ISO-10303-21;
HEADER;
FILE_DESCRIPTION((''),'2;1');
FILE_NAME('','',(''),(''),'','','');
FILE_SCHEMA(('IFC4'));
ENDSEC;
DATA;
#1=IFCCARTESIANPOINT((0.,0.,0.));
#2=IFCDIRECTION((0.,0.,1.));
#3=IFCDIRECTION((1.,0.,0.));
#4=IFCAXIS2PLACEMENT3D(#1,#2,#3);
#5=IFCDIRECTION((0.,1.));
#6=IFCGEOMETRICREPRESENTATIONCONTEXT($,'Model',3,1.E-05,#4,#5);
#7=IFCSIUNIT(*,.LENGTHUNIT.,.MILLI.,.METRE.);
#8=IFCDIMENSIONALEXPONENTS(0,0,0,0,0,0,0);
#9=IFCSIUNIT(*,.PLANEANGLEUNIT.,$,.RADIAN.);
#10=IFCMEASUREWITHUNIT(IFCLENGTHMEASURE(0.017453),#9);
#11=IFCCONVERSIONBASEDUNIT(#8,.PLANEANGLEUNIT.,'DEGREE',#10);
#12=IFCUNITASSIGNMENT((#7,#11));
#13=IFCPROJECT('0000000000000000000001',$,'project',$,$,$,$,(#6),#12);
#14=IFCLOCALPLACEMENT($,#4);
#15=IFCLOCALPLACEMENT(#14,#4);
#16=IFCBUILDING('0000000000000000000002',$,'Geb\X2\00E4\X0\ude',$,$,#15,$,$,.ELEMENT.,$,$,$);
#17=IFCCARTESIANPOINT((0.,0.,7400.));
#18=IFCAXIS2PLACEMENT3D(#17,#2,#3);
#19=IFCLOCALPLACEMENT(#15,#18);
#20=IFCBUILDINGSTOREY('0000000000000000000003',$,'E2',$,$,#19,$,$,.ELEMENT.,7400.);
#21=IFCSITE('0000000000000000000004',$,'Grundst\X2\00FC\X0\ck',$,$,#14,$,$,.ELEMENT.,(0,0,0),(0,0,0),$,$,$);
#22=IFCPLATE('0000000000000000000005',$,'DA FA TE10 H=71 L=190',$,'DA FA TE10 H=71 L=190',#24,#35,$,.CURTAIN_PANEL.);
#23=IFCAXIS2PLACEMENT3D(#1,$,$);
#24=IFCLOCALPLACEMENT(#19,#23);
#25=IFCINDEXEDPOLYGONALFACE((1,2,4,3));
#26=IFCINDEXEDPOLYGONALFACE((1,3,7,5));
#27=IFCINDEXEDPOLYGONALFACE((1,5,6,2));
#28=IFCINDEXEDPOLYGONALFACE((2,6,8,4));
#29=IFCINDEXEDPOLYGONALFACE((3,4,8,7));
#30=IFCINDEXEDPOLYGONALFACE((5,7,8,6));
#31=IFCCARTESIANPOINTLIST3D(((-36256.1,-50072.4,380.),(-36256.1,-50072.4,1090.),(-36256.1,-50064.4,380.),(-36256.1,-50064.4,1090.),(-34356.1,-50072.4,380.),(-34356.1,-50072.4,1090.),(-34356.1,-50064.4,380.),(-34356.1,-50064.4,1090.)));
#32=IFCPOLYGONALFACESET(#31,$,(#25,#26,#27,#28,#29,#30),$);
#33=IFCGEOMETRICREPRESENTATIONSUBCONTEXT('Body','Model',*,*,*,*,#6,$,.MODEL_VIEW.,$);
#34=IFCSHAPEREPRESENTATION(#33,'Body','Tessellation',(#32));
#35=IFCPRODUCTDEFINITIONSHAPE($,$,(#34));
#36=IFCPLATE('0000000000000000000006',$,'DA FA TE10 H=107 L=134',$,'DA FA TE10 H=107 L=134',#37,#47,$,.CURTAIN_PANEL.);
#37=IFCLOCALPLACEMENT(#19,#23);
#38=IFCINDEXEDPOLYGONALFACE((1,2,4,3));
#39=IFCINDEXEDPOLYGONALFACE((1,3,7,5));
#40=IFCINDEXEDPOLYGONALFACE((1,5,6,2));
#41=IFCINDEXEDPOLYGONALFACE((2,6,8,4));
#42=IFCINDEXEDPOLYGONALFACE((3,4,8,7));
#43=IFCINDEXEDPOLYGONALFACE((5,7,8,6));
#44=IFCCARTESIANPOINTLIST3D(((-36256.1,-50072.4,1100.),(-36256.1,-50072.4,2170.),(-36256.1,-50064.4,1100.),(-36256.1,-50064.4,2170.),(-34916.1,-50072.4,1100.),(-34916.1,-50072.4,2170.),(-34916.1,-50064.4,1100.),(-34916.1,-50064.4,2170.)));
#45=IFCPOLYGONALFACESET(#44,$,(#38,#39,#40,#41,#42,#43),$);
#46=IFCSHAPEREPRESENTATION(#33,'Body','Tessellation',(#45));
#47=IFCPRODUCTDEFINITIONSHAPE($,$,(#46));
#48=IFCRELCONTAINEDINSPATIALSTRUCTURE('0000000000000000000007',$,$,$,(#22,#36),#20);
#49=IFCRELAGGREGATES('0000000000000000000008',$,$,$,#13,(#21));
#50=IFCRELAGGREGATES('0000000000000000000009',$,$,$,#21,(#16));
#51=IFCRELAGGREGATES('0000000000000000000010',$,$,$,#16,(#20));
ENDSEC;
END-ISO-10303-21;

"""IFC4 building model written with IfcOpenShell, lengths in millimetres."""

from ifc_helpers import new_model, entity, si_unit, converted_unit, direction, frame, origin_with_axes, place, context, subcontext, project, spatial, line, indexed_curve, outline, extrude, source, transform, mapped, element, save


model = new_model("IFC4")

# Units and contexts
model_context = context("Model", 3, precision=1e-05, world=origin_with_axes(), true_north=direction((0.0, 1.0)))
body_context = subcontext(model_context, "Body", "Model", "MODEL_VIEW")
ifc_project = project(units=[si_unit("LENGTHUNIT", "METRE", prefix="MILLI"), converted_unit("PLANEANGLEUNIT", "DEGREE", entity("IfcLengthMeasure", 0.017453), si_unit("PLANEANGLEUNIT", "RADIAN"), dimensions=[0, 0, 0, 0, 0, 0, 0])], contexts=[model_context])

# Site, building, storey
site_placement = place(None, origin_with_axes())
site = spatial("IfcSite", under=ifc_project, at=site_placement, Name="Grundstück", CompositionType="ELEMENT", RefLatitude=(0, 0, 0), RefLongitude=(0, 0, 0))
building_placement = place(site_placement, origin_with_axes())
building = spatial("IfcBuilding", under=site, at=building_placement, Name="Gebäude", CompositionType="ELEMENT")
storey_placement = place(building_placement, frame((0.0, 0.0, 7400.0), z_axis=(0.0, 0.0, 1.0), x_axis=(1.0, 0.0, 0.0)))
storey = spatial("IfcBuildingStorey", under=building, at=storey_placement, Name="E2", CompositionType="ELEMENT", Elevation=7400.0)

# Plates
shared_shape_1 = source(origin_with_axes(), body_context, "Body", "SweptSolid", [
    extrude(outline(indexed_curve([(-950.0, 0.0), (950.0, 0.0), (950.0, 8.0), (-950.0, 8.0)], segments=[line(1, 2), line(2, 3), line(3, 4), line(4, 1)])), frame((0.0, 0.0, 710.0), z_axis=(0.0, 0.0, 1.0), x_axis=(1.0, 0.0, 0.0)), (0.0, 0.0, -1.0), 710.0),
])
plate_1_placement = place(storey_placement, frame((-35306.1, -50064.4, 380.0), z_axis=(0.0, 0.0, 1.0), x_axis=(-1.0, 0.0, 0.0)))
element("IfcPlate", 1, at=plate_1_placement, inside=storey, Name="DA FA TE10 H=71 L=190", ObjectType="DA FA TE10 H=71 L=190", PredefinedType="CURTAIN_PANEL", context=body_context, shape_type="MappedRepresentation", body=[
    mapped(shared_shape_1, transform((0.0, 0.0, 0.0), x_axis=(1.0, 0.0, 0.0), y_axis=(0.0, 1.0, 0.0), z_axis=(0.0, 0.0, 1.0), scale=1.0)),
])
shared_shape_2 = source(origin_with_axes(), body_context, "Body", "SweptSolid", [
    extrude(outline(indexed_curve([(-670.0, 0.0), (670.0, 0.0), (670.0, 8.0), (-670.0, 8.0)], segments=[line(1, 2), line(2, 3), line(3, 4), line(4, 1)])), frame((0.0, 0.0, 1070.0), z_axis=(0.0, 0.0, 1.0), x_axis=(1.0, 0.0, 0.0)), (0.0, 0.0, -1.0), 1070.0),
])
plate_2_placement = place(storey_placement, frame((-35586.1, -50064.4, 1100.0), z_axis=(0.0, 0.0, 1.0), x_axis=(-1.0, 0.0, 0.0)))
element("IfcPlate", 2, at=plate_2_placement, inside=storey, Name="DA FA TE10 H=107 L=134", ObjectType="DA FA TE10 H=107 L=134", PredefinedType="CURTAIN_PANEL", context=body_context, shape_type="MappedRepresentation", body=[
    mapped(shared_shape_2, transform((0.0, 0.0, 0.0), x_axis=(1.0, 0.0, 0.0), y_axis=(0.0, 1.0, 0.0), z_axis=(0.0, 0.0, 1.0), scale=1.0)),
])

save(model, "model.ifc")
